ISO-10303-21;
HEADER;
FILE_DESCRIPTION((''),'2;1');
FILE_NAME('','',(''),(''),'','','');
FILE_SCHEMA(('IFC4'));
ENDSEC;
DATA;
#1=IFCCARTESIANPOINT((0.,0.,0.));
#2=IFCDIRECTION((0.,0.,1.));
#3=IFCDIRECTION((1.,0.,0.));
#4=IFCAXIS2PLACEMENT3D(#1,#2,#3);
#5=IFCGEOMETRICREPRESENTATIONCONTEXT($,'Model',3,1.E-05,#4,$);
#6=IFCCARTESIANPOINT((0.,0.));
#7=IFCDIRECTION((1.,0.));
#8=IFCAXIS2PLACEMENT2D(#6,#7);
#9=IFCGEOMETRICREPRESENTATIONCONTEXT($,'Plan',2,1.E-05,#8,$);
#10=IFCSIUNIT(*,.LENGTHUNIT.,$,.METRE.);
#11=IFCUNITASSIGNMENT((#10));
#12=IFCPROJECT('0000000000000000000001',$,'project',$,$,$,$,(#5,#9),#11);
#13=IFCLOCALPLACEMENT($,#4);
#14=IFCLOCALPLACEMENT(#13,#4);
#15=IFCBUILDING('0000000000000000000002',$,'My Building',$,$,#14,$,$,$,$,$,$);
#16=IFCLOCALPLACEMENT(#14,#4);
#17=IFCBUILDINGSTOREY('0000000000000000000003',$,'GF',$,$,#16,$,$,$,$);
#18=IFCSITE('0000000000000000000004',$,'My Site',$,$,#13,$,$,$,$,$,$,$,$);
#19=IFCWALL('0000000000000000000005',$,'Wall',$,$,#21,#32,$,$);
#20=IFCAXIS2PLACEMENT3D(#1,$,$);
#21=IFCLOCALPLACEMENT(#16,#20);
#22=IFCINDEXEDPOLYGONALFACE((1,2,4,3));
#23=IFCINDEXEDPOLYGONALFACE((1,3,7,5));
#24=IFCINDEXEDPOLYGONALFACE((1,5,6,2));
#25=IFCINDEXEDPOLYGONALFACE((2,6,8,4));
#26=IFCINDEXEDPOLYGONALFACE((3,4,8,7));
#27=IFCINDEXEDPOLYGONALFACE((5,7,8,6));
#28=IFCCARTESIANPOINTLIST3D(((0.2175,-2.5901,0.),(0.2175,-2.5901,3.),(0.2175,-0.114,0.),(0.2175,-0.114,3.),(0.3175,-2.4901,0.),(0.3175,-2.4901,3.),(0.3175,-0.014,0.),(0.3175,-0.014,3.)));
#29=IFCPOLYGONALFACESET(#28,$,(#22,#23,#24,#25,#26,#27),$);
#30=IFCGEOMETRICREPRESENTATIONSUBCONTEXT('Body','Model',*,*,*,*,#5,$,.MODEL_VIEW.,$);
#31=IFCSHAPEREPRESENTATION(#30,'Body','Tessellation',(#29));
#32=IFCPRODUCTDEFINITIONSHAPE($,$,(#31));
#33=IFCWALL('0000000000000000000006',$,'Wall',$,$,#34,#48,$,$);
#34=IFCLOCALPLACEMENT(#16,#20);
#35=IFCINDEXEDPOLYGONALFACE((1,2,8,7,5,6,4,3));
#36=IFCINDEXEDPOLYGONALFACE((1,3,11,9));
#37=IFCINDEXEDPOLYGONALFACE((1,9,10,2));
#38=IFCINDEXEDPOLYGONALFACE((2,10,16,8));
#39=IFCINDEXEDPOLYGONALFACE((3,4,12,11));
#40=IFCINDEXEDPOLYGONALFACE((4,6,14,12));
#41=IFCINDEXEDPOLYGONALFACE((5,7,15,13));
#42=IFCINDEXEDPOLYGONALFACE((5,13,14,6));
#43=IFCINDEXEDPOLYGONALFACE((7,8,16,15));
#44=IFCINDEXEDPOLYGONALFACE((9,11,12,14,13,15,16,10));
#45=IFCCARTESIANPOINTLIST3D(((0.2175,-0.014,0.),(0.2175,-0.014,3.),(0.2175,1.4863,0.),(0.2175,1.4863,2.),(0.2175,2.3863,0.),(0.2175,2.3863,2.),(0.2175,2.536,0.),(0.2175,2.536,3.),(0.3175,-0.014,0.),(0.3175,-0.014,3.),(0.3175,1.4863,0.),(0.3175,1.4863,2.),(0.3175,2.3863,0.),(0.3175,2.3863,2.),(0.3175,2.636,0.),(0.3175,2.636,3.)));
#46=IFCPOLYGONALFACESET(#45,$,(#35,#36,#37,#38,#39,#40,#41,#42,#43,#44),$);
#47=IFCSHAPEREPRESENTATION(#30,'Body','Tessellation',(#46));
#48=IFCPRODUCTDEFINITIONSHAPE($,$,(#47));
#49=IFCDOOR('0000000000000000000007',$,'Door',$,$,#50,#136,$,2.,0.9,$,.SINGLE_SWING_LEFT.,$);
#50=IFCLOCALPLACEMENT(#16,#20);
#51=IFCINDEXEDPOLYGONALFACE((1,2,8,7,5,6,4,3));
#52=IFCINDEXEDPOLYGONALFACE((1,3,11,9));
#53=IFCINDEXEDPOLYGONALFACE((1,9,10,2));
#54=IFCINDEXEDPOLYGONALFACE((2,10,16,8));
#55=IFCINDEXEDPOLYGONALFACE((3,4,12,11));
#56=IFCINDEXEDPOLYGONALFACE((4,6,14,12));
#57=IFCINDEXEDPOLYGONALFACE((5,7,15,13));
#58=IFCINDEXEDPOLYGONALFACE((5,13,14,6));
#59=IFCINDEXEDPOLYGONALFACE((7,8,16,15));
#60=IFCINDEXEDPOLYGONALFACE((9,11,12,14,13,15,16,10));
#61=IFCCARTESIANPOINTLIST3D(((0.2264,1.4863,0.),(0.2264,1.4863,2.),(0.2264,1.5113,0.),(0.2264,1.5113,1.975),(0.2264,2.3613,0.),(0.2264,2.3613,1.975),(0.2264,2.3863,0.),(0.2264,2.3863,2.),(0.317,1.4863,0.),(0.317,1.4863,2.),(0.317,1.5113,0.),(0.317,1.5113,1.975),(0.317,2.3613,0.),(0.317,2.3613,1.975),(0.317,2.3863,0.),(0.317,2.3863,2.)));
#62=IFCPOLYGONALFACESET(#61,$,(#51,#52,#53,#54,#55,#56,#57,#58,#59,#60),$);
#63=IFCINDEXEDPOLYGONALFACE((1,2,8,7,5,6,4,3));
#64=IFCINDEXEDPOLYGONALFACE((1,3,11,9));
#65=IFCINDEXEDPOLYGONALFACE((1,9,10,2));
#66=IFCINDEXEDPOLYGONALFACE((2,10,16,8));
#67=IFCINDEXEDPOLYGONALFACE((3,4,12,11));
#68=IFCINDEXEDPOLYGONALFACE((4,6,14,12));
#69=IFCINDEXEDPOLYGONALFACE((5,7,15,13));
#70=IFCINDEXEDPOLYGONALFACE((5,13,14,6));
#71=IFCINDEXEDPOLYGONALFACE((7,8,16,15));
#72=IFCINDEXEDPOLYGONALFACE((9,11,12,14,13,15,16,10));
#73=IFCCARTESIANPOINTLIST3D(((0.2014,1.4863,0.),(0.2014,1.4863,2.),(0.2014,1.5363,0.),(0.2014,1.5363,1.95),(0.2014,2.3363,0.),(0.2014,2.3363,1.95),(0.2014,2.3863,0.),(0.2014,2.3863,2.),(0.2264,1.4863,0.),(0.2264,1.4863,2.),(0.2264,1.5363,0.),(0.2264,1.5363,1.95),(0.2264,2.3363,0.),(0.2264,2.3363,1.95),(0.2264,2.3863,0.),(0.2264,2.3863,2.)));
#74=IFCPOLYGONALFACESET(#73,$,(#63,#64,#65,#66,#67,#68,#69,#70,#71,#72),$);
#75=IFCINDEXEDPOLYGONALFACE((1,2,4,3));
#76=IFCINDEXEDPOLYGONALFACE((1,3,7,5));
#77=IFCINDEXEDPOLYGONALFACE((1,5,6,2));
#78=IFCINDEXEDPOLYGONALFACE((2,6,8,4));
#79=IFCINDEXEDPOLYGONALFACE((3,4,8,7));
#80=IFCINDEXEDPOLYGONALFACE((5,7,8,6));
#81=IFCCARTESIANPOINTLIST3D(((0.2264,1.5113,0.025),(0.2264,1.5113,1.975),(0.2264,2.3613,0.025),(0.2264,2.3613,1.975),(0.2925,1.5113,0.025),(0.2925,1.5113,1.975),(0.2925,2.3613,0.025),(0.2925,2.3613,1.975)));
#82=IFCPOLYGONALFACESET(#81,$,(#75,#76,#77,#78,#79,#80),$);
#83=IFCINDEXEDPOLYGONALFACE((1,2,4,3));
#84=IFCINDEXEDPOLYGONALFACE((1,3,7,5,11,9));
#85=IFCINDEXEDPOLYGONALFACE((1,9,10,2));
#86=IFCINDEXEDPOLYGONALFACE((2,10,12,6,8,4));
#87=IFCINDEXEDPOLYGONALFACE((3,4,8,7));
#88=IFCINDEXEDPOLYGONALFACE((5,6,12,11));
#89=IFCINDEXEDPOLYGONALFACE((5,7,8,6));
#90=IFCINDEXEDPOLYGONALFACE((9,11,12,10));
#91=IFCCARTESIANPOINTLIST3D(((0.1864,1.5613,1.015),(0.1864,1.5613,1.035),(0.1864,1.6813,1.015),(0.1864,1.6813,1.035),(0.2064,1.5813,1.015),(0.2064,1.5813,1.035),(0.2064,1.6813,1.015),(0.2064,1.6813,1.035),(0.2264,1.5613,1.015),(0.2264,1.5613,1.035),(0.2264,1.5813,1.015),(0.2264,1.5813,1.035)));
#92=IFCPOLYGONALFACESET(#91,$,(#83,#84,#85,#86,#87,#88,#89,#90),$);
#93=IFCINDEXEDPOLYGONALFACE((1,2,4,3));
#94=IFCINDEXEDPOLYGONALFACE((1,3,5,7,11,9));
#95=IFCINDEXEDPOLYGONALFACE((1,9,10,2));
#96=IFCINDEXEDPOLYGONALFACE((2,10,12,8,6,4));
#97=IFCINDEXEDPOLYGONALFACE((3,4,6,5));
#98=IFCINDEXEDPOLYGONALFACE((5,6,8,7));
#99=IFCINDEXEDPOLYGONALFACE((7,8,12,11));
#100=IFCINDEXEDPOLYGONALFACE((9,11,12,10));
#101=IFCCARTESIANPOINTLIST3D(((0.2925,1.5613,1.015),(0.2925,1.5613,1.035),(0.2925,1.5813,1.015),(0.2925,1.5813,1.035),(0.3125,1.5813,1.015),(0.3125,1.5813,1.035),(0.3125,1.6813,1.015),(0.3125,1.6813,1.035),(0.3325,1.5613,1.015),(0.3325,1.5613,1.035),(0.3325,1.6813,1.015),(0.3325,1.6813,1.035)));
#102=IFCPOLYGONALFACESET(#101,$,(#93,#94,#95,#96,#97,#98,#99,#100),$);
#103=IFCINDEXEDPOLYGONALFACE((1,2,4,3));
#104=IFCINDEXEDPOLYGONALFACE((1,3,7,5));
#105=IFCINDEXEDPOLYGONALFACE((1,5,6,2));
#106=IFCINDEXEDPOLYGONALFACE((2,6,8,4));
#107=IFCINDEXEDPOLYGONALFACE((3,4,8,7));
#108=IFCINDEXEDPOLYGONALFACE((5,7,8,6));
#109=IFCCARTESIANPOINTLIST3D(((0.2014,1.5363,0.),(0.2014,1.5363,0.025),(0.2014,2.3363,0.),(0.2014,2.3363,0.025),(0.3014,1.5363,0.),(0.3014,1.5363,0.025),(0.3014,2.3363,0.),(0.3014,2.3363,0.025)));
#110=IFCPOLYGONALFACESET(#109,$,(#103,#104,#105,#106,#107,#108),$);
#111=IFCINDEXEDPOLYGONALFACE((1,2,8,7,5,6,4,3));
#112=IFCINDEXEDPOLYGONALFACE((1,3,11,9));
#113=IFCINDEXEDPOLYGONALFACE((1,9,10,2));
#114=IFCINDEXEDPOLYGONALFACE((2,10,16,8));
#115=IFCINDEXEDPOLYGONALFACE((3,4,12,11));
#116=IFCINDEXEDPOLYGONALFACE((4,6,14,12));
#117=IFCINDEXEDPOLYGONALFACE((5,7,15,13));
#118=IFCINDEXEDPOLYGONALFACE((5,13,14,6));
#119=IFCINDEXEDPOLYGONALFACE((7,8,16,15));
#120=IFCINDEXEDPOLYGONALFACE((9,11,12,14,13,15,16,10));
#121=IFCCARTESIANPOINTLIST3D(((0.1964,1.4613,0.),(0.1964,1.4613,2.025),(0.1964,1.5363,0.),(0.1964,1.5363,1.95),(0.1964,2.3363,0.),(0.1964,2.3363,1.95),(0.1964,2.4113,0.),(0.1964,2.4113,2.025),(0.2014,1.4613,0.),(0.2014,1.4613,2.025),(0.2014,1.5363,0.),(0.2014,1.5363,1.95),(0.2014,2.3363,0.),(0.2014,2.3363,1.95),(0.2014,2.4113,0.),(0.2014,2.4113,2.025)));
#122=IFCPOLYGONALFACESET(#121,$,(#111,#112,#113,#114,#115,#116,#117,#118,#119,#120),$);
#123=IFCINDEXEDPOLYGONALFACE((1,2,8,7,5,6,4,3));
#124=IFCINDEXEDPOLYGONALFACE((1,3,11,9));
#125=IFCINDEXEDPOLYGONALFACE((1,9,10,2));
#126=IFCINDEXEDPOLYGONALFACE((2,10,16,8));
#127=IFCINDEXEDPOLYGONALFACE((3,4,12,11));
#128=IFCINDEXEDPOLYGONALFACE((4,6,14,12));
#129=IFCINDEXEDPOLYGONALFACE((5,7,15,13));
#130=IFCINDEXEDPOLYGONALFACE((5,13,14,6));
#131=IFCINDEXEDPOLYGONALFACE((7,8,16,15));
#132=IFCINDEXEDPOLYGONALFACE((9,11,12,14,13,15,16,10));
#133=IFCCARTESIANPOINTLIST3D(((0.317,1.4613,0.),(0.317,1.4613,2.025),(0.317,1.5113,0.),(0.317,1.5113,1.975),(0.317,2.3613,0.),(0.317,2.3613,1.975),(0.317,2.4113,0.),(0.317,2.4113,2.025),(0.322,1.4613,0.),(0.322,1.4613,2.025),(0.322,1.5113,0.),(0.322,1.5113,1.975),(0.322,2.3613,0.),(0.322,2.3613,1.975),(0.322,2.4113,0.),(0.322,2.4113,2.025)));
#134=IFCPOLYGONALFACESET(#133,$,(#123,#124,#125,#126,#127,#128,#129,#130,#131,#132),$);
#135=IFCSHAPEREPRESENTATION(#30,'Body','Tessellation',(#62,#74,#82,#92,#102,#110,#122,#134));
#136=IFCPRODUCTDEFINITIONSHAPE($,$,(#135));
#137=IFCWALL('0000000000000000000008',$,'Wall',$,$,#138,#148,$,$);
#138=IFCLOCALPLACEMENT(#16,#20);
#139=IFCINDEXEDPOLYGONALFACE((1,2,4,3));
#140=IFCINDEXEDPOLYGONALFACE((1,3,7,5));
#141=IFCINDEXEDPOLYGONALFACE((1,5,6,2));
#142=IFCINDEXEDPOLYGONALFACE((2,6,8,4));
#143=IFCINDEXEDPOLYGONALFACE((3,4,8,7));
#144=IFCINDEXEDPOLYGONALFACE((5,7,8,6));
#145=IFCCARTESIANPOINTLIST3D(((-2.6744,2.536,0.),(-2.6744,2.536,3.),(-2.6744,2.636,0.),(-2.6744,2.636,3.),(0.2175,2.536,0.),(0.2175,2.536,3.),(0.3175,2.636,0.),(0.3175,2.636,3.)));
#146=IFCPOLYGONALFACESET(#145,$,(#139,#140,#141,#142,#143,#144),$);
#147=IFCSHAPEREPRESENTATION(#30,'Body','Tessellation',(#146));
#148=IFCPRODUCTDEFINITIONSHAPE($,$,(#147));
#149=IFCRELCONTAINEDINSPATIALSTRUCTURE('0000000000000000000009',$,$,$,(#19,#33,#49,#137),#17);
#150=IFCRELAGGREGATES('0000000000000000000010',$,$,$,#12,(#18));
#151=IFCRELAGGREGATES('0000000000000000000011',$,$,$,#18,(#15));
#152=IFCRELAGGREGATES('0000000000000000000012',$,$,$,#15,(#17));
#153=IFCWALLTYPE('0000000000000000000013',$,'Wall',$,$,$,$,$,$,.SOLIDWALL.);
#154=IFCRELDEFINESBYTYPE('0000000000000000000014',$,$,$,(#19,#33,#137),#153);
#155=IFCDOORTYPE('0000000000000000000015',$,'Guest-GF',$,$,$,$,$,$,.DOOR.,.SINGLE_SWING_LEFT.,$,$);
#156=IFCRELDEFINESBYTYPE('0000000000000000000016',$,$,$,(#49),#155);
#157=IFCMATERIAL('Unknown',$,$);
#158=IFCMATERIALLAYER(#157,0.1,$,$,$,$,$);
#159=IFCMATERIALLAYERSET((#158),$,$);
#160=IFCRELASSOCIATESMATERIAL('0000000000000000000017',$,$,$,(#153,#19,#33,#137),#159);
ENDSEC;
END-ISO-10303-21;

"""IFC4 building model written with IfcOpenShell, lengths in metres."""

from ifc_helpers import new_model, entity, si_unit, frame, origin_with_axes, origin_2d_with_axis, place, context, subcontext, project, spatial, line, indexed_curve, outline, extrude, shape, source, transform, mapped, material, layer, layer_set, layer_usage, type_object, type_shapes, element, fill, save


model = new_model("IFC4")

# Units and contexts
model_context = context("Model", 3, precision=1e-05, world=origin_with_axes())
plan_context = context("Plan", 2, precision=1e-05, world=origin_2d_with_axis())
body_context_1 = subcontext(model_context, "Body", "Model", "MODEL_VIEW")
body_context_2 = subcontext(plan_context, "Body", "Plan", "PLAN_VIEW")
ifc_project = project(units=[si_unit("LENGTHUNIT", "METRE")], contexts=[model_context, plan_context])

# Site, building, storey
site_placement = place(None, origin_with_axes())
site = spatial("IfcSite", under=ifc_project, at=site_placement, Name="My Site")
building_placement = place(site_placement, origin_with_axes())
building = spatial("IfcBuilding", under=site, at=building_placement, Name="My Building")
storey_placement = place(building_placement, origin_with_axes())
storey = spatial("IfcBuildingStorey", under=building, at=storey_placement, Name="GF")

# Shared definitions
ifc_material = material(Name="Unknown")

# Shared definitions
ifc_layer_1 = layer(ifc_material, 0.1)
ifc_layer_set_1 = layer_set([ifc_layer_1])
wall_type = type_object("IfcWallType", Name="Wall", PredefinedType="SOLIDWALL", material=ifc_layer_set_1)

# Wall
ifc_layer_usage_1 = layer_usage(ifc_layer_set_1, "AXIS2", "POSITIVE", 0.0)
wall_1_placement = place(storey_placement, frame((0.2175, -0.114, 0.0), z_axis=(0.0, 0.0, 1.0), x_axis=(0.0, -1.0, 0.0)))
element("IfcWall", 1, at=wall_1_placement, inside=storey, type_object=wall_type, material=ifc_layer_usage_1, Name="Wall", context=body_context_1, shape_type="SweptSolid", body=[
    extrude(outline(indexed_curve([(0.0, 0.0), (-0.1, 0.1), (2.3761, 0.1), (2.4761, 0.0)], segments=[line(1, 2, 3, 4, 1)])), origin_with_axes(), (0.0, 0.0, 1.0), 3.0),
])

# Wall, opening, door
ifc_layer_usage_2 = layer_usage(ifc_layer_set_1, "AXIS2", "POSITIVE", 0.0)
wall_2_placement = place(storey_placement, frame((0.3175, -0.114, 0.0), z_axis=(0.0, 0.0, 1.0), x_axis=(0.0, 1.0, 0.0)))
wall_2 = element("IfcWall", 2, at=wall_2_placement, inside=storey, type_object=wall_type, material=ifc_layer_usage_2, Name="Wall", context=body_context_1, shape_type="SweptSolid", body=[
    extrude(outline(indexed_curve([(0.1, 0.0), (0.1, 0.1), (2.65, 0.1), (2.75, 0.0)], segments=[line(1, 2, 3, 4, 1)])), origin_with_axes(), (0.0, 0.0, 1.0), 3.0),
])
shared_shape_1 = source(origin_with_axes(), body_context_1, "Body", "SweptSolid", [
    extrude(outline(indexed_curve([(0.0, 0.0), (0.9, 0.0), (0.9, 2.0), (0.0, 2.0)], segments=[line(1, 2, 3, 4, 1)])), frame((0.0, -0.6, 0.0), z_axis=(0.0, -1.0, 0.0), x_axis=(1.0, 0.0, 0.0)), (0.0, 0.0, -1.0), 1.2),
])
opening_1_placement = place(wall_2_placement, frame((2.5003, 0.1161, 0.0), z_axis=(0.0, 0.0, 1.0), x_axis=(-1.0, 0.0, 0.0)))
opening_1 = element("IfcOpeningElement", 3, at=opening_1_placement, cuts=wall_2, PredefinedType="OPENING", context=body_context_1, shape_type="MappedRepresentation", body=[
    mapped(shared_shape_1, transform((0.0, 0.0, 0.0), x_axis=(1.0, 0.0, 0.0), y_axis=(0.0, 1.0, 0.0), z_axis=(0.0, 0.0, 1.0), scale=1.0)),
])
door_type_1 = type_object("IfcDoorType", Name="Guest-GF", OperationType="SINGLE_SWING_LEFT", PredefinedType="DOOR")
shared_shape_2 = source(origin_with_axes(), body_context_1, "Body", "SweptSolid", [
    extrude(outline(indexed_curve([(0.0, 0.0), (0.0, 2.0), (0.9, 2.0), (0.9, 0.0), (0.875, 0.0), (0.875, 1.975), (0.025, 1.975), (0.025, 0.0)], segments=[line(1, 2, 3, 4, 5, 6, 7, 8, 1)])), frame((0.0, 0.025, 0.0), z_axis=(0.0, -1.0, 0.0), x_axis=(1.0, 0.0, 0.0)), (0.0, 0.0, -1.0), 0.0906),
    extrude(outline(indexed_curve([(0.0, 0.0), (0.0, 2.0), (0.9, 2.0), (0.9, 0.0), (0.85, 0.0), (0.85, 1.95), (0.05, 1.95), (0.05, 0.0)], segments=[line(1, 2, 3, 4, 5, 6, 7, 8, 1)])), frame((0.0, 0.0, 0.0), z_axis=(0.0, -1.0, 0.0), x_axis=(1.0, 0.0, 0.0)), (0.0, 0.0, -1.0), 0.025),
    extrude(outline(indexed_curve([(0.0, 0.0), (0.85, 0.0), (0.85, 0.0661), (0.0, 0.0661)], segments=[line(1, 2, 3, 4, 1)])), frame((0.025, 0.025, 0.025), z_axis=(0.0, 0.0, 1.0), x_axis=(1.0, 0.0, 0.0)), (0.0, 0.0, 1.0), 1.95),
    extrude(outline(indexed_curve([(0.0, 0.0), (0.0, -0.04), (-0.12, -0.04), (-0.12, -0.02), (-0.02, -0.02), (-0.02, 0.0)], segments=[line(1, 2, 3, 4, 5, 6, 1)])), frame((0.825, 0.025, 1.015), z_axis=(0.0, 0.0, 1.0), x_axis=(1.0, 0.0, 0.0)), (0.0, 0.0, 1.0), 0.02),
    extrude(outline(indexed_curve([(0.0, 0.0), (0.0, 0.04), (-0.12, 0.04), (-0.12, 0.02), (-0.02, 0.02), (-0.02, 0.0)], segments=[line(1, 2, 3, 4, 5, 6, 1)])), frame((0.825, 0.0911, 1.015), z_axis=(0.0, 0.0, 1.0), x_axis=(1.0, 0.0, 0.0)), (0.0, 0.0, 1.0), 0.02),
    extrude(outline(indexed_curve([(0.0, 0.0), (0.8, 0.0), (0.8, 0.1), (0.0, 0.1)], segments=[line(1, 2, 3, 4, 1)])), frame((0.05, 0.0, 0.0), z_axis=(0.0, 0.0, 1.0), x_axis=(1.0, 0.0, 0.0)), (0.0, 0.0, 1.0), 0.025),
    extrude(outline(indexed_curve([(0.0, 0.0), (0.0, 2.025), (0.95, 2.025), (0.95, 0.0), (0.875, 0.0), (0.875, 1.95), (0.075, 1.95), (0.075, 0.0)], segments=[line(1, 2, 3, 4, 5, 6, 7, 8, 1)])), frame((-0.025, -0.005, 0.0), z_axis=(0.0, -1.0, 0.0), x_axis=(1.0, 0.0, 0.0)), (0.0, 0.0, -1.0), 0.005),
    extrude(outline(indexed_curve([(0.0, 0.0), (0.0, 2.025), (0.95, 2.025), (0.95, 0.0), (0.9, 0.0), (0.9, 1.975), (0.05, 1.975), (0.05, 0.0)], segments=[line(1, 2, 3, 4, 5, 6, 7, 8, 1)])), frame((-0.025, 0.1156, 0.0), z_axis=(0.0, -1.0, 0.0), x_axis=(1.0, 0.0, 0.0)), (0.0, 0.0, -1.0), 0.005),
])
shared_shape_3 = source(origin_with_axes(), body_context_2, "Body", "Curve2D", [
    entity("IfcIndexedPolyCurve", entity("IfcCartesianPointList2D", [[0.0, 0.0], [0.0, 0.1156], [0.025, 0.1156], [0.025, 0.025], [0.05, 0.025], [0.05, 0.0]]), [entity("IfcLineIndex", [1, 2, 3, 4, 5, 6, 1])]),
    entity("IfcIndexedPolyCurve", entity("IfcCartesianPointList2D", [[0.9, 0.0], [0.9, 0.1156], [0.875, 0.1156], [0.875, 0.025], [0.85, 0.025], [0.85, 0.0]]), [entity("IfcLineIndex", [1, 2, 3, 4, 5, 6, 1])]),
    entity("IfcTrimmedCurve", entity("IfcEllipse", entity("IfcAxis2Placement2D", entity("IfcCartesianPoint", [0.0911, 0.1156]), entity("IfcDirection", [1.0, 0.0])), 0.7839, 0.85), [entity("IfcCartesianPoint", [0.875, 0.1156])], [entity("IfcCartesianPoint", [0.0911, 0.9656])], True, "CARTESIAN"),
    entity("IfcIndexedPolyCurve", entity("IfcCartesianPointList2D", [[0.025, 0.1156], [0.0911, 0.1156], [0.0911, 0.9656], [0.025, 0.9656]]), [entity("IfcLineIndex", [1, 2, 3, 4, 1])]),
])
type_shapes(door_type_1, [shared_shape_2, shared_shape_3])
door_1_placement = place(opening_1_placement, frame((0.0, 0.0, 0.0), z_axis=(0.0, 0.0, 1.0), x_axis=(1.0, 0.0, 0.0)))
door_1 = element("IfcDoor", 4, at=door_1_placement, inside=storey, type_object=door_type_1, Name="Door", OperationType="SINGLE_SWING_LEFT", OverallHeight=2.0, OverallWidth=0.9, shapes=[
    shape(body_context_1, "Body", "MappedRepresentation", [mapped(shared_shape_2, transform((0.0, 0.0, 0.0), x_axis=(1.0, 0.0, 0.0), y_axis=(0.0, 1.0, 0.0), z_axis=(0.0, 0.0, 1.0), scale=1.0))]),
    shape(body_context_2, "Body", "MappedRepresentation", [mapped(shared_shape_3, transform((0.0, 0.0, 0.0), x_axis=(1.0, 0.0, 0.0), y_axis=(0.0, 1.0, 0.0), z_axis=(0.0, 0.0, 1.0), scale=1.0))]),
])
fill(opening_1, door_1)

# Wall
ifc_layer_usage_3 = layer_usage(ifc_layer_set_1, "AXIS2", "POSITIVE", 0.0)
wall_3_placement = place(storey_placement, frame((0.3175, 2.636, 0.0), z_axis=(0.0, 0.0, 1.0), x_axis=(-1.0, 0.0, 0.0)))
element("IfcWall", 5, at=wall_3_placement, inside=storey, type_object=wall_type, material=ifc_layer_usage_3, Name="Wall", context=body_context_1, shape_type="SweptSolid", body=[
    extrude(outline(indexed_curve([(0.0, 0.0), (0.1, 0.1), (2.9919, 0.1), (2.9919, 0.0)], segments=[line(1, 2, 3, 4, 1)])), origin_with_axes(), (0.0, 0.0, 1.0), 3.0),
])

save(model, "model.ifc")
